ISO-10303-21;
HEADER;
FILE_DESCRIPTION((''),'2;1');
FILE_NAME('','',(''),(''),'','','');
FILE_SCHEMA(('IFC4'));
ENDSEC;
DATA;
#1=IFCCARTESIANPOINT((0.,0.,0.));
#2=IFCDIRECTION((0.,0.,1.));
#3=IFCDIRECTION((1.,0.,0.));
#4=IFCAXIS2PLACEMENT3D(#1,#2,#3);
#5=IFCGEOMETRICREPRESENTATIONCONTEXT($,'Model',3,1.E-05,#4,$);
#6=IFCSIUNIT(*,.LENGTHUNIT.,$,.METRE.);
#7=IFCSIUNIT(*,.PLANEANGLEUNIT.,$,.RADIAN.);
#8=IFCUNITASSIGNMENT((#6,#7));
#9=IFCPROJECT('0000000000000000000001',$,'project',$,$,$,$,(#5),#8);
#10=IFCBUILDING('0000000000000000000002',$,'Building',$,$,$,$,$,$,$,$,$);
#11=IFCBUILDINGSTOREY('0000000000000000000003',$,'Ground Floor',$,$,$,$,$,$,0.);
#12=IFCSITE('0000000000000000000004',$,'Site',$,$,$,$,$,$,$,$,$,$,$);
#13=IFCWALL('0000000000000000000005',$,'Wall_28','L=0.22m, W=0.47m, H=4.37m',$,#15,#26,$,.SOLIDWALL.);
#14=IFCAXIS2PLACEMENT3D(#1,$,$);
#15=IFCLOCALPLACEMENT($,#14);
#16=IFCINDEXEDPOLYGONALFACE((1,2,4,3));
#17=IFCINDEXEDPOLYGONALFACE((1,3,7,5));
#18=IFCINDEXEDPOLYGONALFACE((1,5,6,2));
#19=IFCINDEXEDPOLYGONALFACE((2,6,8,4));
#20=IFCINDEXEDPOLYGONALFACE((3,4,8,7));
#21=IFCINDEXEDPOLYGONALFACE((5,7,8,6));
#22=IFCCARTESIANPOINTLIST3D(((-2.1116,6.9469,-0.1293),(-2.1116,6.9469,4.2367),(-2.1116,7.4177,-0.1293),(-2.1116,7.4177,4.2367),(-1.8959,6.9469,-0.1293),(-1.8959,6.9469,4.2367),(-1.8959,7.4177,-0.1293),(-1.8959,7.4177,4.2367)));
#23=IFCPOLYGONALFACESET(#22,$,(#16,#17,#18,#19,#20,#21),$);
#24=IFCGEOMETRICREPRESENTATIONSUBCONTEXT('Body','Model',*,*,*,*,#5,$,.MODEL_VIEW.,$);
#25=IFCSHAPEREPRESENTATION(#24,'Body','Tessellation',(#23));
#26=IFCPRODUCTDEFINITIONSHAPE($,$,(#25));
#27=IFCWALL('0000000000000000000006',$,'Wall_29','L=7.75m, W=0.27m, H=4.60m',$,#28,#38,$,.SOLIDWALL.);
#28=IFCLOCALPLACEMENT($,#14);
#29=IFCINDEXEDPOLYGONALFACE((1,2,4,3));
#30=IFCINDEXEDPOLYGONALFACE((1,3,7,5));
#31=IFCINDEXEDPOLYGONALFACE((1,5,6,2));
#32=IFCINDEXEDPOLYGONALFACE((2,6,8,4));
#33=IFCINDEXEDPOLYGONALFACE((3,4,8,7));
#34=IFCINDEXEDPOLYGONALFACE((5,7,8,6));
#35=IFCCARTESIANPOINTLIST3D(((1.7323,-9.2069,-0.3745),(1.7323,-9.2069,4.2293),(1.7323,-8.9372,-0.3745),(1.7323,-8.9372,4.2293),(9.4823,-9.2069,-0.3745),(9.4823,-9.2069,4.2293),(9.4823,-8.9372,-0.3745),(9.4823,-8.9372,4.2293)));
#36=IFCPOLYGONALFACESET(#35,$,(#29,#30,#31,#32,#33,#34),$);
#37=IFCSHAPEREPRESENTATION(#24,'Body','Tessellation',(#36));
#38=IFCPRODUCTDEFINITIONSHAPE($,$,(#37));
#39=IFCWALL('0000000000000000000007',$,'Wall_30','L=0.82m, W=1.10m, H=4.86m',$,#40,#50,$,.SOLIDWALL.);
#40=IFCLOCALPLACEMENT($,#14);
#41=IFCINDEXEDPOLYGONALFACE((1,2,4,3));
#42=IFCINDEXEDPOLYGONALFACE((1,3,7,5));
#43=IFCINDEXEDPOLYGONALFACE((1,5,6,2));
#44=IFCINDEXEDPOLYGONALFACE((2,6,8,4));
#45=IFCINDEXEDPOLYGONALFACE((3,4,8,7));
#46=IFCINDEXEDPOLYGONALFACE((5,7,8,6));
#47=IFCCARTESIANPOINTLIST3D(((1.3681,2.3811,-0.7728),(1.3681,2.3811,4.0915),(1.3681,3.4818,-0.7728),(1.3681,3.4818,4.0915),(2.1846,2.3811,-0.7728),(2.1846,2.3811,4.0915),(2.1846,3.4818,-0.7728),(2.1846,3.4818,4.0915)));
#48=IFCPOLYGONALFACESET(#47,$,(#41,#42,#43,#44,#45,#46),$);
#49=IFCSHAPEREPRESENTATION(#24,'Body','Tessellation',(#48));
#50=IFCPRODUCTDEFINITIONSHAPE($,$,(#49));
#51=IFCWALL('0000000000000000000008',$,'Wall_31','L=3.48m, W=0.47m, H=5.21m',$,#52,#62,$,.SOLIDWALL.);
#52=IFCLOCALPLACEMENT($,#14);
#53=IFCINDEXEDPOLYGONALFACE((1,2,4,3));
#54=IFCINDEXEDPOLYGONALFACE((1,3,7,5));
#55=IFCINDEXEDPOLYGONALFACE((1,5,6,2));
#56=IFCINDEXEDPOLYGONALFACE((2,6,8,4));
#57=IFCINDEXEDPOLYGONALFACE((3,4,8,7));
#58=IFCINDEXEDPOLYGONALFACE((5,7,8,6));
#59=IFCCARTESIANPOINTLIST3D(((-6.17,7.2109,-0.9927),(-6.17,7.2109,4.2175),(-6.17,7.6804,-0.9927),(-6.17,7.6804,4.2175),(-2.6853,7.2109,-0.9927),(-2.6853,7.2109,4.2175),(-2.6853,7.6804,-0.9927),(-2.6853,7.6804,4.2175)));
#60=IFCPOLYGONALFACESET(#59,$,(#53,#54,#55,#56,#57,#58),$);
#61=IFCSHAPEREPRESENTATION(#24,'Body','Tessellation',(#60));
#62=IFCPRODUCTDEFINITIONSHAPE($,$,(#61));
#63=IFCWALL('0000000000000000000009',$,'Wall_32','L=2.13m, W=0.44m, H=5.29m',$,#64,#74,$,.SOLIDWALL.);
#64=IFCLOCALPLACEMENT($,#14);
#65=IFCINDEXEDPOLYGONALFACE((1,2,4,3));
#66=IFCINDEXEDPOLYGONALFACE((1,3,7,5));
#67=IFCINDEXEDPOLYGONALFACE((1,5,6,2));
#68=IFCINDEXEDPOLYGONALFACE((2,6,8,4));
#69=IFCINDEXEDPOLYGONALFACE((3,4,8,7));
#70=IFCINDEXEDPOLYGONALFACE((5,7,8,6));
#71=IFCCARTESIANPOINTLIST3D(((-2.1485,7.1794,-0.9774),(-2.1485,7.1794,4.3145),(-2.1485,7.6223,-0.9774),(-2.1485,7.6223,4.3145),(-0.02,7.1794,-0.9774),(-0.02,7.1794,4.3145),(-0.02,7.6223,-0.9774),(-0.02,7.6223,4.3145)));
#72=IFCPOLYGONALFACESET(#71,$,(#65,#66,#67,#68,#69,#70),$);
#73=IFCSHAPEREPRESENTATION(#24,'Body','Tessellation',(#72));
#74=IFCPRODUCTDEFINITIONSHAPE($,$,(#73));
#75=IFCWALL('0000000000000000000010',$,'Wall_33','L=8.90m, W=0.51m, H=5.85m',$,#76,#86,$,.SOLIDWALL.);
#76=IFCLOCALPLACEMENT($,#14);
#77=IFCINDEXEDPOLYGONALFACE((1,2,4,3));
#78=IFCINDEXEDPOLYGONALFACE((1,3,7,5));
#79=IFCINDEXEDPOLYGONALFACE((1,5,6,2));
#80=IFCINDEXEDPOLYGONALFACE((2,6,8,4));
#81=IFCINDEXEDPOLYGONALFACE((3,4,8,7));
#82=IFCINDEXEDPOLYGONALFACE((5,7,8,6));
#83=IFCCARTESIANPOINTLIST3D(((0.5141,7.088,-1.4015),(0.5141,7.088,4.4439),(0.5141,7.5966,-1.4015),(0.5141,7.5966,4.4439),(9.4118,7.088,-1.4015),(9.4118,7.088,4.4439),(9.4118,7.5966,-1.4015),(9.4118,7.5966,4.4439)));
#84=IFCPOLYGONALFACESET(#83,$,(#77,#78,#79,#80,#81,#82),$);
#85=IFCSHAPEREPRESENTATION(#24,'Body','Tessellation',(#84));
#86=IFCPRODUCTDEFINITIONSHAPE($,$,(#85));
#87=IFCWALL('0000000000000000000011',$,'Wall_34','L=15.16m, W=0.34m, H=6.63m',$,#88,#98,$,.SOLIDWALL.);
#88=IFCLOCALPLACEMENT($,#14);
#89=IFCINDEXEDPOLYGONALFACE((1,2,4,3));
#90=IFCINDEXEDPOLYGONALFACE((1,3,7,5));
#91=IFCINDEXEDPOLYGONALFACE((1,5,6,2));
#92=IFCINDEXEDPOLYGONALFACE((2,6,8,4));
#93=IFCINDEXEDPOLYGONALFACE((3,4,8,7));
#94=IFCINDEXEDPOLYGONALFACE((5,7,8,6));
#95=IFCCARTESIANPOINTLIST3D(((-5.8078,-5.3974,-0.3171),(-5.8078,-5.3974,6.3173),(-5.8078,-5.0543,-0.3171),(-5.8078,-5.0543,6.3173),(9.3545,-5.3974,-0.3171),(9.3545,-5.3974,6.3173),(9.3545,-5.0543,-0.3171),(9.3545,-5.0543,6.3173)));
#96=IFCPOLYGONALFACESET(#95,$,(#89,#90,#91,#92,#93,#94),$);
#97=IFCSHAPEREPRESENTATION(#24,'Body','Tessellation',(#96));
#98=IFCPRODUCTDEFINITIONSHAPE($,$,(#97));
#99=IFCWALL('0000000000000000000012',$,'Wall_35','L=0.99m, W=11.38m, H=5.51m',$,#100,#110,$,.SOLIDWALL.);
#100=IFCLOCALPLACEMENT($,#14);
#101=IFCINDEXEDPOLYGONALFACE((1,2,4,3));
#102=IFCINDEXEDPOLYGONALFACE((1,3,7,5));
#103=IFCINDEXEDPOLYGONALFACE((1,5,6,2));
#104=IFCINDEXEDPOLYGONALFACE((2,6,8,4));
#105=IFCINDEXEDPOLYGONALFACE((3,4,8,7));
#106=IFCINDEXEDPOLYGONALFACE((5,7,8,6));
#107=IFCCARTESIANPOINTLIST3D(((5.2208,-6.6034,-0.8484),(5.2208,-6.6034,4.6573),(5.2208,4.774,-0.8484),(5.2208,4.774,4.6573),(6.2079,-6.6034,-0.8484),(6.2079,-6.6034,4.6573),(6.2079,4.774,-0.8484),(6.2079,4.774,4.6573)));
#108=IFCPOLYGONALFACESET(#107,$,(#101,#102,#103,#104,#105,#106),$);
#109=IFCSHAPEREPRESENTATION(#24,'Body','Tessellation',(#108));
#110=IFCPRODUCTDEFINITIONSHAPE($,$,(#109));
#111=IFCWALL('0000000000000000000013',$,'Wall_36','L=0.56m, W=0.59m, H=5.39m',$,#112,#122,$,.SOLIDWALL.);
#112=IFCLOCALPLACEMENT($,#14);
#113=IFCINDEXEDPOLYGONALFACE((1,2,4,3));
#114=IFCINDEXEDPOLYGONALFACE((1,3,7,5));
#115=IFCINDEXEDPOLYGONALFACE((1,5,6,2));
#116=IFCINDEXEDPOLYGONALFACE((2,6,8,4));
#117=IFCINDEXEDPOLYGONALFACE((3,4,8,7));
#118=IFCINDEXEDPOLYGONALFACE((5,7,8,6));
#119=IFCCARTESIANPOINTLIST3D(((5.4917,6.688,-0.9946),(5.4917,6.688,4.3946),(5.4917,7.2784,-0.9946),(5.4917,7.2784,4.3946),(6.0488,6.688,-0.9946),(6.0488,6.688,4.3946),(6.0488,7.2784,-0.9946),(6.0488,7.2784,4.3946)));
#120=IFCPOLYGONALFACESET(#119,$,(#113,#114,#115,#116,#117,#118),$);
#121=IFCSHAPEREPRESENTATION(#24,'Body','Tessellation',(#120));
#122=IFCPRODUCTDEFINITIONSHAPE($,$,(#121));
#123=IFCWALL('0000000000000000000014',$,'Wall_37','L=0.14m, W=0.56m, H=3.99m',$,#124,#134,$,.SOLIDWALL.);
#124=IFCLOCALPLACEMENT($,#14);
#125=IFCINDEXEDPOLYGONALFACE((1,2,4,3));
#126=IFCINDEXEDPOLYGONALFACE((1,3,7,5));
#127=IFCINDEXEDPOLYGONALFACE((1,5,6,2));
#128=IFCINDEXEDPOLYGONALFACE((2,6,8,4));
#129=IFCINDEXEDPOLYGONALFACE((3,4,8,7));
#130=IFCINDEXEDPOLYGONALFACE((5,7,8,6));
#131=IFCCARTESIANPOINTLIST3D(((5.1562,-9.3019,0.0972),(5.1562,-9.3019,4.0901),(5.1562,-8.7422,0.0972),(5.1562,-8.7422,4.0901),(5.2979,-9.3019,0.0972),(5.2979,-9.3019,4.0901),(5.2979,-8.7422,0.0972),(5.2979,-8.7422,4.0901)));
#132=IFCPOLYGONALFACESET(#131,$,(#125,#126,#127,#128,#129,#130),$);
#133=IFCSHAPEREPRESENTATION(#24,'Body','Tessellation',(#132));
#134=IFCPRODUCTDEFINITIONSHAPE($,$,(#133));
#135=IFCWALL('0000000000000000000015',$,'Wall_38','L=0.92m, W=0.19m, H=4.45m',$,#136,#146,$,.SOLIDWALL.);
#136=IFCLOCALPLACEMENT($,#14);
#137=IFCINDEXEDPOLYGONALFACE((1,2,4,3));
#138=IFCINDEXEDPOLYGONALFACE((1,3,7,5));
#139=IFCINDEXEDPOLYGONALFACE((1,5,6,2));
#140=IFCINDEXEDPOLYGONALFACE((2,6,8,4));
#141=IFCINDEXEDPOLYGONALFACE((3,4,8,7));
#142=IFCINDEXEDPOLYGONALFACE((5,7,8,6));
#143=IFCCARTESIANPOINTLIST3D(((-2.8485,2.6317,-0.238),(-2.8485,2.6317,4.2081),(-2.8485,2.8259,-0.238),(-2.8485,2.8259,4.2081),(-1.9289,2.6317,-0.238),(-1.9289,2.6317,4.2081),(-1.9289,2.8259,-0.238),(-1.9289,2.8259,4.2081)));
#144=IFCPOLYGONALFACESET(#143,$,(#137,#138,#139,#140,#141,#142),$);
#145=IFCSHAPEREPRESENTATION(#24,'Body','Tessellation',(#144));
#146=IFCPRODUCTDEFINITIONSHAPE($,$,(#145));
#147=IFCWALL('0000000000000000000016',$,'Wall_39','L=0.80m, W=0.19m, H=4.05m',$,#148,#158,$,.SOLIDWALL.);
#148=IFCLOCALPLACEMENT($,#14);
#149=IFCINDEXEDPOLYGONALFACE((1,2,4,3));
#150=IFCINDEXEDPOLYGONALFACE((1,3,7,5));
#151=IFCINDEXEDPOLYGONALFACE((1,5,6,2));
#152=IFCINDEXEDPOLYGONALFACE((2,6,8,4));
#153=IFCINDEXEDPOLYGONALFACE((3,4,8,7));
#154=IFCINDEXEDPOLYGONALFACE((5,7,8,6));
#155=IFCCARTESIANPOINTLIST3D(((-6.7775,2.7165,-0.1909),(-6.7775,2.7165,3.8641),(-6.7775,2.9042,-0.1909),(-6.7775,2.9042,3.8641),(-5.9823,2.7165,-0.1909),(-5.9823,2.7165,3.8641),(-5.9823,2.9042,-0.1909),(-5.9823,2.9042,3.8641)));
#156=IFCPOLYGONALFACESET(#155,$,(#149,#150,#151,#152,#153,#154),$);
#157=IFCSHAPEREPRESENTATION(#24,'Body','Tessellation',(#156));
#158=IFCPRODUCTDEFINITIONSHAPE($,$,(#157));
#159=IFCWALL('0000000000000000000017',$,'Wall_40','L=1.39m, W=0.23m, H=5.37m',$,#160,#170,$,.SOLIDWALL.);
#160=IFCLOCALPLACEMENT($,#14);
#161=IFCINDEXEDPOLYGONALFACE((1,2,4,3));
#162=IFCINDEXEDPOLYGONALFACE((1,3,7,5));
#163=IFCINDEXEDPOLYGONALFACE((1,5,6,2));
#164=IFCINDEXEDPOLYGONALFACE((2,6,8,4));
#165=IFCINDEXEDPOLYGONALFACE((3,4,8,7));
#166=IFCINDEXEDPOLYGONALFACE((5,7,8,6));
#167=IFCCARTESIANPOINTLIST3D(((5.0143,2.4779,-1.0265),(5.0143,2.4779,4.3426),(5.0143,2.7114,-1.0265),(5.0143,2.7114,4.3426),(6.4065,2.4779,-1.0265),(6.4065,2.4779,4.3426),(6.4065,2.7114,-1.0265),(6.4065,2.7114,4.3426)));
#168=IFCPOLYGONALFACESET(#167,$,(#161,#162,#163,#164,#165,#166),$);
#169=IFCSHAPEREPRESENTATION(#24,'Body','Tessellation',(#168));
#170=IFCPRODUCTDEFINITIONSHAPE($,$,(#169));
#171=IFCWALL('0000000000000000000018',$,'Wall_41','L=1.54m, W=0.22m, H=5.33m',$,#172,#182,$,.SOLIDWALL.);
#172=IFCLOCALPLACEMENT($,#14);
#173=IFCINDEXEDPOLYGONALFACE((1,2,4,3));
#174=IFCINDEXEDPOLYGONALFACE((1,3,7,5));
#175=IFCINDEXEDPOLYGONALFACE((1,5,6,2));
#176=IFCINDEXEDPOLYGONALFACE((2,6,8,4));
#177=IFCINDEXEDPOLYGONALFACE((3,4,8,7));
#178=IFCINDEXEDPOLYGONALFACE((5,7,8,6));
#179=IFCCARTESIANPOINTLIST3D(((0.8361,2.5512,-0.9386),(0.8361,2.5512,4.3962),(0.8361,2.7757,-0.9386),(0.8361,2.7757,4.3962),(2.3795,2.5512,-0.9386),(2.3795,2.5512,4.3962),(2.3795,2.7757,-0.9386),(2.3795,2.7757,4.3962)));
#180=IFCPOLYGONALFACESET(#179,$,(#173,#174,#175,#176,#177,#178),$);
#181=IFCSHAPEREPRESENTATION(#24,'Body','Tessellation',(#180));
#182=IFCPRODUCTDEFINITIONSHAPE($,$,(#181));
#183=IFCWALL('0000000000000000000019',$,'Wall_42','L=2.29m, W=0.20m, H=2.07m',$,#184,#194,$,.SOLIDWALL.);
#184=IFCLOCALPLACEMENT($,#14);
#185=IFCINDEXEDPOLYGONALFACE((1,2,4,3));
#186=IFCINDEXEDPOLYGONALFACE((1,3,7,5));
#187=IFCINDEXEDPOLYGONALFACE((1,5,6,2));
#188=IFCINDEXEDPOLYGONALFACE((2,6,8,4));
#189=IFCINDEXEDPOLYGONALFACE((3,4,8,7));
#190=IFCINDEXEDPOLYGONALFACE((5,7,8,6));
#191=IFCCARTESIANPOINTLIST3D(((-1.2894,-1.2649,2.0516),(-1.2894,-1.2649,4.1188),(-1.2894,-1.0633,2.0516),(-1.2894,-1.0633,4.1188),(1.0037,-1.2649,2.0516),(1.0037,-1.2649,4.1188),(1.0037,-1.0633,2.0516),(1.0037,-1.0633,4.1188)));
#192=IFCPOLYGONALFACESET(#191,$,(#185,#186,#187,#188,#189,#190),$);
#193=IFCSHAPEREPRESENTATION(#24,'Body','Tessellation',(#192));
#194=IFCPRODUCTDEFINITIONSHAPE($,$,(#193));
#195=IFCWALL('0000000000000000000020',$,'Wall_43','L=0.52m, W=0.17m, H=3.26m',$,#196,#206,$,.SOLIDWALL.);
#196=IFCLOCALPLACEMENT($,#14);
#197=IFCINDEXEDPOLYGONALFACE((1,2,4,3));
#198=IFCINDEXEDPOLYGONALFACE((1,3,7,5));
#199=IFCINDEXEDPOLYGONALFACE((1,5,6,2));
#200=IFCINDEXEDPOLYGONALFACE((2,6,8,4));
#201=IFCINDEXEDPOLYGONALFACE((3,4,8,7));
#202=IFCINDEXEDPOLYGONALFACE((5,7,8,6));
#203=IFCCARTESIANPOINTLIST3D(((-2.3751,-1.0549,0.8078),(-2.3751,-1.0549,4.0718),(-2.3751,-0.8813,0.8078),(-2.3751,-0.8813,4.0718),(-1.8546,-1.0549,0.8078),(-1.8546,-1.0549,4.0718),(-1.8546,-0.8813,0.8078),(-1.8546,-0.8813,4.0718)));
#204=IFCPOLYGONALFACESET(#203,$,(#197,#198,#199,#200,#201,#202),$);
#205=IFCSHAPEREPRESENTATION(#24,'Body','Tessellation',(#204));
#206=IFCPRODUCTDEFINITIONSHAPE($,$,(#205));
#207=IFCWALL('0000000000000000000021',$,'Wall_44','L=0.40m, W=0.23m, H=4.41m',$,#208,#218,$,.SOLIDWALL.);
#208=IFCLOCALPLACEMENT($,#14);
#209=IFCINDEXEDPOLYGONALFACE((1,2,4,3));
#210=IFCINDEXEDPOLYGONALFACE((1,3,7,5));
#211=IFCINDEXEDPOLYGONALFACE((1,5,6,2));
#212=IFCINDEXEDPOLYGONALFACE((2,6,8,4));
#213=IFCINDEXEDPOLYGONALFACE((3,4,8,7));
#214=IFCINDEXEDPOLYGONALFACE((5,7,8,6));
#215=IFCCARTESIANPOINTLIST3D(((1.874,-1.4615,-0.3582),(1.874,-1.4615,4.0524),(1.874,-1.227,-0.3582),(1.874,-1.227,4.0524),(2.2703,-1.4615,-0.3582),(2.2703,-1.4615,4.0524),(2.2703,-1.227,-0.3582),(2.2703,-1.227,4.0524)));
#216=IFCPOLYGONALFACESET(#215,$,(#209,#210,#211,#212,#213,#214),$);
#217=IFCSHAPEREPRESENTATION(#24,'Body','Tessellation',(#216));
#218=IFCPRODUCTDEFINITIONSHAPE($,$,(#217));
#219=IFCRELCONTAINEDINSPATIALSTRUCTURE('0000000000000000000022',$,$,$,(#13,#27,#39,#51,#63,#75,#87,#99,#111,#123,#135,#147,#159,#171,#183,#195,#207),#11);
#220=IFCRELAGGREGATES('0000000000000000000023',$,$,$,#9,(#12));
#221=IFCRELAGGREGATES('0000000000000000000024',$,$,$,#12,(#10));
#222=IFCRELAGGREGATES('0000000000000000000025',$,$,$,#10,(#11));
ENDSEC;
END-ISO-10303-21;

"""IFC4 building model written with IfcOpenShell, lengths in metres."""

from ifc_helpers import new_model, si_unit, frame, origin_with_axes, origin_2d, context, subcontext, project, spatial, rectangle, extrude, element, save


model = new_model("IFC4")

# Units and contexts
model_context = context("Model", 3, precision=1e-05, world=origin_with_axes())
body_context = subcontext(model_context, "Body", "Model", "MODEL_VIEW")
ifc_project = project(units=[si_unit("LENGTHUNIT", "METRE"), si_unit("PLANEANGLEUNIT", "RADIAN")], contexts=[model_context])

# Site, building, storey
site = spatial("IfcSite", under=ifc_project, Name="Site")
building = spatial("IfcBuilding", under=site, Name="Building")
storey = spatial("IfcBuildingStorey", under=building, Name="Ground Floor", Elevation=0.0)

# Walls
element("IfcWall", 1, inside=storey, Name="Wall_28", Description="L=0.22m, W=0.47m, H=4.37m", PredefinedType="SOLIDWALL", context=body_context, shape_type="SweptSolid", body=[
    extrude(rectangle(XDim=0.2157, YDim=0.4708, at=origin_2d()), frame((-2.0037, 7.1823, -0.1293), z_axis=(0.0, 0.0, 1.0), x_axis=(1.0, 0.0, 0.0)), (0.0, 0.0, 1.0), 4.366),
])
element("IfcWall", 2, inside=storey, Name="Wall_29", Description="L=7.75m, W=0.27m, H=4.60m", PredefinedType="SOLIDWALL", context=body_context, shape_type="SweptSolid", body=[
    extrude(rectangle(XDim=7.7499, YDim=0.2697, at=origin_2d()), frame((5.6073, -9.072, -0.3745), z_axis=(0.0, 0.0, 1.0), x_axis=(1.0, 0.0, 0.0)), (0.0, 0.0, 1.0), 4.6038),
])
element("IfcWall", 3, inside=storey, Name="Wall_30", Description="L=0.82m, W=1.10m, H=4.86m", PredefinedType="SOLIDWALL", context=body_context, shape_type="SweptSolid", body=[
    extrude(rectangle(XDim=0.8165, YDim=1.1007, at=origin_2d()), frame((1.7764, 2.9314, -0.7728), z_axis=(0.0, 0.0, 1.0), x_axis=(1.0, 0.0, 0.0)), (0.0, 0.0, 1.0), 4.8643),
])
element("IfcWall", 4, inside=storey, Name="Wall_31", Description="L=3.48m, W=0.47m, H=5.21m", PredefinedType="SOLIDWALL", context=body_context, shape_type="SweptSolid", body=[
    extrude(rectangle(XDim=3.4847, YDim=0.4695, at=origin_2d()), frame((-4.4276, 7.4457, -0.9927), z_axis=(0.0, 0.0, 1.0), x_axis=(1.0, 0.0, 0.0)), (0.0, 0.0, 1.0), 5.2102),
])
element("IfcWall", 5, inside=storey, Name="Wall_32", Description="L=2.13m, W=0.44m, H=5.29m", PredefinedType="SOLIDWALL", context=body_context, shape_type="SweptSolid", body=[
    extrude(rectangle(XDim=2.1285, YDim=0.4429, at=origin_2d()), frame((-1.0842, 7.4009, -0.9774), z_axis=(0.0, 0.0, 1.0), x_axis=(1.0, 0.0, 0.0)), (0.0, 0.0, 1.0), 5.2919),
])
element("IfcWall", 6, inside=storey, Name="Wall_33", Description="L=8.90m, W=0.51m, H=5.85m", PredefinedType="SOLIDWALL", context=body_context, shape_type="SweptSolid", body=[
    extrude(rectangle(XDim=8.8977, YDim=0.5085, at=origin_2d()), frame((4.9629, 7.3423, -1.4015), z_axis=(0.0, 0.0, 1.0), x_axis=(1.0, 0.0, 0.0)), (0.0, 0.0, 1.0), 5.8454),
])
element("IfcWall", 7, inside=storey, Name="Wall_34", Description="L=15.16m, W=0.34m, H=6.63m", PredefinedType="SOLIDWALL", context=body_context, shape_type="SweptSolid", body=[
    extrude(rectangle(XDim=15.1623, YDim=0.3431, at=origin_2d()), frame((1.7733, -5.2258, -0.3171), z_axis=(0.0, 0.0, 1.0), x_axis=(1.0, 0.0, 0.0)), (0.0, 0.0, 1.0), 6.6344),
])
element("IfcWall", 8, inside=storey, Name="Wall_35", Description="L=0.99m, W=11.38m, H=5.51m", PredefinedType="SOLIDWALL", context=body_context, shape_type="SweptSolid", body=[
    extrude(rectangle(XDim=0.9872, YDim=11.3773, at=origin_2d()), frame((5.7144, -0.9147, -0.8484), z_axis=(0.0, 0.0, 1.0), x_axis=(1.0, 0.0, 0.0)), (0.0, 0.0, 1.0), 5.5057),
])
element("IfcWall", 9, inside=storey, Name="Wall_36", Description="L=0.56m, W=0.59m, H=5.39m", PredefinedType="SOLIDWALL", context=body_context, shape_type="SweptSolid", body=[
    extrude(rectangle(XDim=0.557, YDim=0.5904, at=origin_2d()), frame((5.7703, 6.9832, -0.9946), z_axis=(0.0, 0.0, 1.0), x_axis=(1.0, 0.0, 0.0)), (0.0, 0.0, 1.0), 5.3891),
])
element("IfcWall", 10, inside=storey, Name="Wall_37", Description="L=0.14m, W=0.56m, H=3.99m", PredefinedType="SOLIDWALL", context=body_context, shape_type="SweptSolid", body=[
    extrude(rectangle(XDim=0.1417, YDim=0.5597, at=origin_2d()), frame((5.227, -9.0221, 0.0972), z_axis=(0.0, 0.0, 1.0), x_axis=(1.0, 0.0, 0.0)), (0.0, 0.0, 1.0), 3.9929),
])
element("IfcWall", 11, inside=storey, Name="Wall_38", Description="L=0.92m, W=0.19m, H=4.45m", PredefinedType="SOLIDWALL", context=body_context, shape_type="SweptSolid", body=[
    extrude(rectangle(XDim=0.9196, YDim=0.1942, at=origin_2d()), frame((-2.3887, 2.7288, -0.238), z_axis=(0.0, 0.0, 1.0), x_axis=(1.0, 0.0, 0.0)), (0.0, 0.0, 1.0), 4.4461),
])
element("IfcWall", 12, inside=storey, Name="Wall_39", Description="L=0.80m, W=0.19m, H=4.05m", PredefinedType="SOLIDWALL", context=body_context, shape_type="SweptSolid", body=[
    extrude(rectangle(XDim=0.7952, YDim=0.1877, at=origin_2d()), frame((-6.3799, 2.8103, -0.1909), z_axis=(0.0, 0.0, 1.0), x_axis=(1.0, 0.0, 0.0)), (0.0, 0.0, 1.0), 4.055),
])
element("IfcWall", 13, inside=storey, Name="Wall_40", Description="L=1.39m, W=0.23m, H=5.37m", PredefinedType="SOLIDWALL", context=body_context, shape_type="SweptSolid", body=[
    extrude(rectangle(XDim=1.3922, YDim=0.2334, at=origin_2d()), frame((5.7104, 2.5946, -1.0265), z_axis=(0.0, 0.0, 1.0), x_axis=(1.0, 0.0, 0.0)), (0.0, 0.0, 1.0), 5.369),
])
element("IfcWall", 14, inside=storey, Name="Wall_41", Description="L=1.54m, W=0.22m, H=5.33m", PredefinedType="SOLIDWALL", context=body_context, shape_type="SweptSolid", body=[
    extrude(rectangle(XDim=1.5434, YDim=0.2246, at=origin_2d()), frame((1.6078, 2.6634, -0.9386), z_axis=(0.0, 0.0, 1.0), x_axis=(1.0, 0.0, 0.0)), (0.0, 0.0, 1.0), 5.3348),
])
element("IfcWall", 15, inside=storey, Name="Wall_42", Description="L=2.29m, W=0.20m, H=2.07m", PredefinedType="SOLIDWALL", context=body_context, shape_type="SweptSolid", body=[
    extrude(rectangle(XDim=2.293, YDim=0.2016, at=origin_2d()), frame((-0.1429, -1.1641, 2.0516), z_axis=(0.0, 0.0, 1.0), x_axis=(1.0, 0.0, 0.0)), (0.0, 0.0, 1.0), 2.0672),
])
element("IfcWall", 16, inside=storey, Name="Wall_43", Description="L=0.52m, W=0.17m, H=3.26m", PredefinedType="SOLIDWALL", context=body_context, shape_type="SweptSolid", body=[
    extrude(rectangle(XDim=0.5205, YDim=0.1736, at=origin_2d()), frame((-2.1148, -0.9681, 0.8078), z_axis=(0.0, 0.0, 1.0), x_axis=(1.0, 0.0, 0.0)), (0.0, 0.0, 1.0), 3.264),
])
element("IfcWall", 17, inside=storey, Name="Wall_44", Description="L=0.40m, W=0.23m, H=4.41m", PredefinedType="SOLIDWALL", context=body_context, shape_type="SweptSolid", body=[
    extrude(rectangle(XDim=0.3962, YDim=0.2344, at=origin_2d()), frame((2.0721, -1.3442, -0.3582), z_axis=(0.0, 0.0, 1.0), x_axis=(1.0, 0.0, 0.0)), (0.0, 0.0, 1.0), 4.4106),
])

save(model, "model.ifc")
